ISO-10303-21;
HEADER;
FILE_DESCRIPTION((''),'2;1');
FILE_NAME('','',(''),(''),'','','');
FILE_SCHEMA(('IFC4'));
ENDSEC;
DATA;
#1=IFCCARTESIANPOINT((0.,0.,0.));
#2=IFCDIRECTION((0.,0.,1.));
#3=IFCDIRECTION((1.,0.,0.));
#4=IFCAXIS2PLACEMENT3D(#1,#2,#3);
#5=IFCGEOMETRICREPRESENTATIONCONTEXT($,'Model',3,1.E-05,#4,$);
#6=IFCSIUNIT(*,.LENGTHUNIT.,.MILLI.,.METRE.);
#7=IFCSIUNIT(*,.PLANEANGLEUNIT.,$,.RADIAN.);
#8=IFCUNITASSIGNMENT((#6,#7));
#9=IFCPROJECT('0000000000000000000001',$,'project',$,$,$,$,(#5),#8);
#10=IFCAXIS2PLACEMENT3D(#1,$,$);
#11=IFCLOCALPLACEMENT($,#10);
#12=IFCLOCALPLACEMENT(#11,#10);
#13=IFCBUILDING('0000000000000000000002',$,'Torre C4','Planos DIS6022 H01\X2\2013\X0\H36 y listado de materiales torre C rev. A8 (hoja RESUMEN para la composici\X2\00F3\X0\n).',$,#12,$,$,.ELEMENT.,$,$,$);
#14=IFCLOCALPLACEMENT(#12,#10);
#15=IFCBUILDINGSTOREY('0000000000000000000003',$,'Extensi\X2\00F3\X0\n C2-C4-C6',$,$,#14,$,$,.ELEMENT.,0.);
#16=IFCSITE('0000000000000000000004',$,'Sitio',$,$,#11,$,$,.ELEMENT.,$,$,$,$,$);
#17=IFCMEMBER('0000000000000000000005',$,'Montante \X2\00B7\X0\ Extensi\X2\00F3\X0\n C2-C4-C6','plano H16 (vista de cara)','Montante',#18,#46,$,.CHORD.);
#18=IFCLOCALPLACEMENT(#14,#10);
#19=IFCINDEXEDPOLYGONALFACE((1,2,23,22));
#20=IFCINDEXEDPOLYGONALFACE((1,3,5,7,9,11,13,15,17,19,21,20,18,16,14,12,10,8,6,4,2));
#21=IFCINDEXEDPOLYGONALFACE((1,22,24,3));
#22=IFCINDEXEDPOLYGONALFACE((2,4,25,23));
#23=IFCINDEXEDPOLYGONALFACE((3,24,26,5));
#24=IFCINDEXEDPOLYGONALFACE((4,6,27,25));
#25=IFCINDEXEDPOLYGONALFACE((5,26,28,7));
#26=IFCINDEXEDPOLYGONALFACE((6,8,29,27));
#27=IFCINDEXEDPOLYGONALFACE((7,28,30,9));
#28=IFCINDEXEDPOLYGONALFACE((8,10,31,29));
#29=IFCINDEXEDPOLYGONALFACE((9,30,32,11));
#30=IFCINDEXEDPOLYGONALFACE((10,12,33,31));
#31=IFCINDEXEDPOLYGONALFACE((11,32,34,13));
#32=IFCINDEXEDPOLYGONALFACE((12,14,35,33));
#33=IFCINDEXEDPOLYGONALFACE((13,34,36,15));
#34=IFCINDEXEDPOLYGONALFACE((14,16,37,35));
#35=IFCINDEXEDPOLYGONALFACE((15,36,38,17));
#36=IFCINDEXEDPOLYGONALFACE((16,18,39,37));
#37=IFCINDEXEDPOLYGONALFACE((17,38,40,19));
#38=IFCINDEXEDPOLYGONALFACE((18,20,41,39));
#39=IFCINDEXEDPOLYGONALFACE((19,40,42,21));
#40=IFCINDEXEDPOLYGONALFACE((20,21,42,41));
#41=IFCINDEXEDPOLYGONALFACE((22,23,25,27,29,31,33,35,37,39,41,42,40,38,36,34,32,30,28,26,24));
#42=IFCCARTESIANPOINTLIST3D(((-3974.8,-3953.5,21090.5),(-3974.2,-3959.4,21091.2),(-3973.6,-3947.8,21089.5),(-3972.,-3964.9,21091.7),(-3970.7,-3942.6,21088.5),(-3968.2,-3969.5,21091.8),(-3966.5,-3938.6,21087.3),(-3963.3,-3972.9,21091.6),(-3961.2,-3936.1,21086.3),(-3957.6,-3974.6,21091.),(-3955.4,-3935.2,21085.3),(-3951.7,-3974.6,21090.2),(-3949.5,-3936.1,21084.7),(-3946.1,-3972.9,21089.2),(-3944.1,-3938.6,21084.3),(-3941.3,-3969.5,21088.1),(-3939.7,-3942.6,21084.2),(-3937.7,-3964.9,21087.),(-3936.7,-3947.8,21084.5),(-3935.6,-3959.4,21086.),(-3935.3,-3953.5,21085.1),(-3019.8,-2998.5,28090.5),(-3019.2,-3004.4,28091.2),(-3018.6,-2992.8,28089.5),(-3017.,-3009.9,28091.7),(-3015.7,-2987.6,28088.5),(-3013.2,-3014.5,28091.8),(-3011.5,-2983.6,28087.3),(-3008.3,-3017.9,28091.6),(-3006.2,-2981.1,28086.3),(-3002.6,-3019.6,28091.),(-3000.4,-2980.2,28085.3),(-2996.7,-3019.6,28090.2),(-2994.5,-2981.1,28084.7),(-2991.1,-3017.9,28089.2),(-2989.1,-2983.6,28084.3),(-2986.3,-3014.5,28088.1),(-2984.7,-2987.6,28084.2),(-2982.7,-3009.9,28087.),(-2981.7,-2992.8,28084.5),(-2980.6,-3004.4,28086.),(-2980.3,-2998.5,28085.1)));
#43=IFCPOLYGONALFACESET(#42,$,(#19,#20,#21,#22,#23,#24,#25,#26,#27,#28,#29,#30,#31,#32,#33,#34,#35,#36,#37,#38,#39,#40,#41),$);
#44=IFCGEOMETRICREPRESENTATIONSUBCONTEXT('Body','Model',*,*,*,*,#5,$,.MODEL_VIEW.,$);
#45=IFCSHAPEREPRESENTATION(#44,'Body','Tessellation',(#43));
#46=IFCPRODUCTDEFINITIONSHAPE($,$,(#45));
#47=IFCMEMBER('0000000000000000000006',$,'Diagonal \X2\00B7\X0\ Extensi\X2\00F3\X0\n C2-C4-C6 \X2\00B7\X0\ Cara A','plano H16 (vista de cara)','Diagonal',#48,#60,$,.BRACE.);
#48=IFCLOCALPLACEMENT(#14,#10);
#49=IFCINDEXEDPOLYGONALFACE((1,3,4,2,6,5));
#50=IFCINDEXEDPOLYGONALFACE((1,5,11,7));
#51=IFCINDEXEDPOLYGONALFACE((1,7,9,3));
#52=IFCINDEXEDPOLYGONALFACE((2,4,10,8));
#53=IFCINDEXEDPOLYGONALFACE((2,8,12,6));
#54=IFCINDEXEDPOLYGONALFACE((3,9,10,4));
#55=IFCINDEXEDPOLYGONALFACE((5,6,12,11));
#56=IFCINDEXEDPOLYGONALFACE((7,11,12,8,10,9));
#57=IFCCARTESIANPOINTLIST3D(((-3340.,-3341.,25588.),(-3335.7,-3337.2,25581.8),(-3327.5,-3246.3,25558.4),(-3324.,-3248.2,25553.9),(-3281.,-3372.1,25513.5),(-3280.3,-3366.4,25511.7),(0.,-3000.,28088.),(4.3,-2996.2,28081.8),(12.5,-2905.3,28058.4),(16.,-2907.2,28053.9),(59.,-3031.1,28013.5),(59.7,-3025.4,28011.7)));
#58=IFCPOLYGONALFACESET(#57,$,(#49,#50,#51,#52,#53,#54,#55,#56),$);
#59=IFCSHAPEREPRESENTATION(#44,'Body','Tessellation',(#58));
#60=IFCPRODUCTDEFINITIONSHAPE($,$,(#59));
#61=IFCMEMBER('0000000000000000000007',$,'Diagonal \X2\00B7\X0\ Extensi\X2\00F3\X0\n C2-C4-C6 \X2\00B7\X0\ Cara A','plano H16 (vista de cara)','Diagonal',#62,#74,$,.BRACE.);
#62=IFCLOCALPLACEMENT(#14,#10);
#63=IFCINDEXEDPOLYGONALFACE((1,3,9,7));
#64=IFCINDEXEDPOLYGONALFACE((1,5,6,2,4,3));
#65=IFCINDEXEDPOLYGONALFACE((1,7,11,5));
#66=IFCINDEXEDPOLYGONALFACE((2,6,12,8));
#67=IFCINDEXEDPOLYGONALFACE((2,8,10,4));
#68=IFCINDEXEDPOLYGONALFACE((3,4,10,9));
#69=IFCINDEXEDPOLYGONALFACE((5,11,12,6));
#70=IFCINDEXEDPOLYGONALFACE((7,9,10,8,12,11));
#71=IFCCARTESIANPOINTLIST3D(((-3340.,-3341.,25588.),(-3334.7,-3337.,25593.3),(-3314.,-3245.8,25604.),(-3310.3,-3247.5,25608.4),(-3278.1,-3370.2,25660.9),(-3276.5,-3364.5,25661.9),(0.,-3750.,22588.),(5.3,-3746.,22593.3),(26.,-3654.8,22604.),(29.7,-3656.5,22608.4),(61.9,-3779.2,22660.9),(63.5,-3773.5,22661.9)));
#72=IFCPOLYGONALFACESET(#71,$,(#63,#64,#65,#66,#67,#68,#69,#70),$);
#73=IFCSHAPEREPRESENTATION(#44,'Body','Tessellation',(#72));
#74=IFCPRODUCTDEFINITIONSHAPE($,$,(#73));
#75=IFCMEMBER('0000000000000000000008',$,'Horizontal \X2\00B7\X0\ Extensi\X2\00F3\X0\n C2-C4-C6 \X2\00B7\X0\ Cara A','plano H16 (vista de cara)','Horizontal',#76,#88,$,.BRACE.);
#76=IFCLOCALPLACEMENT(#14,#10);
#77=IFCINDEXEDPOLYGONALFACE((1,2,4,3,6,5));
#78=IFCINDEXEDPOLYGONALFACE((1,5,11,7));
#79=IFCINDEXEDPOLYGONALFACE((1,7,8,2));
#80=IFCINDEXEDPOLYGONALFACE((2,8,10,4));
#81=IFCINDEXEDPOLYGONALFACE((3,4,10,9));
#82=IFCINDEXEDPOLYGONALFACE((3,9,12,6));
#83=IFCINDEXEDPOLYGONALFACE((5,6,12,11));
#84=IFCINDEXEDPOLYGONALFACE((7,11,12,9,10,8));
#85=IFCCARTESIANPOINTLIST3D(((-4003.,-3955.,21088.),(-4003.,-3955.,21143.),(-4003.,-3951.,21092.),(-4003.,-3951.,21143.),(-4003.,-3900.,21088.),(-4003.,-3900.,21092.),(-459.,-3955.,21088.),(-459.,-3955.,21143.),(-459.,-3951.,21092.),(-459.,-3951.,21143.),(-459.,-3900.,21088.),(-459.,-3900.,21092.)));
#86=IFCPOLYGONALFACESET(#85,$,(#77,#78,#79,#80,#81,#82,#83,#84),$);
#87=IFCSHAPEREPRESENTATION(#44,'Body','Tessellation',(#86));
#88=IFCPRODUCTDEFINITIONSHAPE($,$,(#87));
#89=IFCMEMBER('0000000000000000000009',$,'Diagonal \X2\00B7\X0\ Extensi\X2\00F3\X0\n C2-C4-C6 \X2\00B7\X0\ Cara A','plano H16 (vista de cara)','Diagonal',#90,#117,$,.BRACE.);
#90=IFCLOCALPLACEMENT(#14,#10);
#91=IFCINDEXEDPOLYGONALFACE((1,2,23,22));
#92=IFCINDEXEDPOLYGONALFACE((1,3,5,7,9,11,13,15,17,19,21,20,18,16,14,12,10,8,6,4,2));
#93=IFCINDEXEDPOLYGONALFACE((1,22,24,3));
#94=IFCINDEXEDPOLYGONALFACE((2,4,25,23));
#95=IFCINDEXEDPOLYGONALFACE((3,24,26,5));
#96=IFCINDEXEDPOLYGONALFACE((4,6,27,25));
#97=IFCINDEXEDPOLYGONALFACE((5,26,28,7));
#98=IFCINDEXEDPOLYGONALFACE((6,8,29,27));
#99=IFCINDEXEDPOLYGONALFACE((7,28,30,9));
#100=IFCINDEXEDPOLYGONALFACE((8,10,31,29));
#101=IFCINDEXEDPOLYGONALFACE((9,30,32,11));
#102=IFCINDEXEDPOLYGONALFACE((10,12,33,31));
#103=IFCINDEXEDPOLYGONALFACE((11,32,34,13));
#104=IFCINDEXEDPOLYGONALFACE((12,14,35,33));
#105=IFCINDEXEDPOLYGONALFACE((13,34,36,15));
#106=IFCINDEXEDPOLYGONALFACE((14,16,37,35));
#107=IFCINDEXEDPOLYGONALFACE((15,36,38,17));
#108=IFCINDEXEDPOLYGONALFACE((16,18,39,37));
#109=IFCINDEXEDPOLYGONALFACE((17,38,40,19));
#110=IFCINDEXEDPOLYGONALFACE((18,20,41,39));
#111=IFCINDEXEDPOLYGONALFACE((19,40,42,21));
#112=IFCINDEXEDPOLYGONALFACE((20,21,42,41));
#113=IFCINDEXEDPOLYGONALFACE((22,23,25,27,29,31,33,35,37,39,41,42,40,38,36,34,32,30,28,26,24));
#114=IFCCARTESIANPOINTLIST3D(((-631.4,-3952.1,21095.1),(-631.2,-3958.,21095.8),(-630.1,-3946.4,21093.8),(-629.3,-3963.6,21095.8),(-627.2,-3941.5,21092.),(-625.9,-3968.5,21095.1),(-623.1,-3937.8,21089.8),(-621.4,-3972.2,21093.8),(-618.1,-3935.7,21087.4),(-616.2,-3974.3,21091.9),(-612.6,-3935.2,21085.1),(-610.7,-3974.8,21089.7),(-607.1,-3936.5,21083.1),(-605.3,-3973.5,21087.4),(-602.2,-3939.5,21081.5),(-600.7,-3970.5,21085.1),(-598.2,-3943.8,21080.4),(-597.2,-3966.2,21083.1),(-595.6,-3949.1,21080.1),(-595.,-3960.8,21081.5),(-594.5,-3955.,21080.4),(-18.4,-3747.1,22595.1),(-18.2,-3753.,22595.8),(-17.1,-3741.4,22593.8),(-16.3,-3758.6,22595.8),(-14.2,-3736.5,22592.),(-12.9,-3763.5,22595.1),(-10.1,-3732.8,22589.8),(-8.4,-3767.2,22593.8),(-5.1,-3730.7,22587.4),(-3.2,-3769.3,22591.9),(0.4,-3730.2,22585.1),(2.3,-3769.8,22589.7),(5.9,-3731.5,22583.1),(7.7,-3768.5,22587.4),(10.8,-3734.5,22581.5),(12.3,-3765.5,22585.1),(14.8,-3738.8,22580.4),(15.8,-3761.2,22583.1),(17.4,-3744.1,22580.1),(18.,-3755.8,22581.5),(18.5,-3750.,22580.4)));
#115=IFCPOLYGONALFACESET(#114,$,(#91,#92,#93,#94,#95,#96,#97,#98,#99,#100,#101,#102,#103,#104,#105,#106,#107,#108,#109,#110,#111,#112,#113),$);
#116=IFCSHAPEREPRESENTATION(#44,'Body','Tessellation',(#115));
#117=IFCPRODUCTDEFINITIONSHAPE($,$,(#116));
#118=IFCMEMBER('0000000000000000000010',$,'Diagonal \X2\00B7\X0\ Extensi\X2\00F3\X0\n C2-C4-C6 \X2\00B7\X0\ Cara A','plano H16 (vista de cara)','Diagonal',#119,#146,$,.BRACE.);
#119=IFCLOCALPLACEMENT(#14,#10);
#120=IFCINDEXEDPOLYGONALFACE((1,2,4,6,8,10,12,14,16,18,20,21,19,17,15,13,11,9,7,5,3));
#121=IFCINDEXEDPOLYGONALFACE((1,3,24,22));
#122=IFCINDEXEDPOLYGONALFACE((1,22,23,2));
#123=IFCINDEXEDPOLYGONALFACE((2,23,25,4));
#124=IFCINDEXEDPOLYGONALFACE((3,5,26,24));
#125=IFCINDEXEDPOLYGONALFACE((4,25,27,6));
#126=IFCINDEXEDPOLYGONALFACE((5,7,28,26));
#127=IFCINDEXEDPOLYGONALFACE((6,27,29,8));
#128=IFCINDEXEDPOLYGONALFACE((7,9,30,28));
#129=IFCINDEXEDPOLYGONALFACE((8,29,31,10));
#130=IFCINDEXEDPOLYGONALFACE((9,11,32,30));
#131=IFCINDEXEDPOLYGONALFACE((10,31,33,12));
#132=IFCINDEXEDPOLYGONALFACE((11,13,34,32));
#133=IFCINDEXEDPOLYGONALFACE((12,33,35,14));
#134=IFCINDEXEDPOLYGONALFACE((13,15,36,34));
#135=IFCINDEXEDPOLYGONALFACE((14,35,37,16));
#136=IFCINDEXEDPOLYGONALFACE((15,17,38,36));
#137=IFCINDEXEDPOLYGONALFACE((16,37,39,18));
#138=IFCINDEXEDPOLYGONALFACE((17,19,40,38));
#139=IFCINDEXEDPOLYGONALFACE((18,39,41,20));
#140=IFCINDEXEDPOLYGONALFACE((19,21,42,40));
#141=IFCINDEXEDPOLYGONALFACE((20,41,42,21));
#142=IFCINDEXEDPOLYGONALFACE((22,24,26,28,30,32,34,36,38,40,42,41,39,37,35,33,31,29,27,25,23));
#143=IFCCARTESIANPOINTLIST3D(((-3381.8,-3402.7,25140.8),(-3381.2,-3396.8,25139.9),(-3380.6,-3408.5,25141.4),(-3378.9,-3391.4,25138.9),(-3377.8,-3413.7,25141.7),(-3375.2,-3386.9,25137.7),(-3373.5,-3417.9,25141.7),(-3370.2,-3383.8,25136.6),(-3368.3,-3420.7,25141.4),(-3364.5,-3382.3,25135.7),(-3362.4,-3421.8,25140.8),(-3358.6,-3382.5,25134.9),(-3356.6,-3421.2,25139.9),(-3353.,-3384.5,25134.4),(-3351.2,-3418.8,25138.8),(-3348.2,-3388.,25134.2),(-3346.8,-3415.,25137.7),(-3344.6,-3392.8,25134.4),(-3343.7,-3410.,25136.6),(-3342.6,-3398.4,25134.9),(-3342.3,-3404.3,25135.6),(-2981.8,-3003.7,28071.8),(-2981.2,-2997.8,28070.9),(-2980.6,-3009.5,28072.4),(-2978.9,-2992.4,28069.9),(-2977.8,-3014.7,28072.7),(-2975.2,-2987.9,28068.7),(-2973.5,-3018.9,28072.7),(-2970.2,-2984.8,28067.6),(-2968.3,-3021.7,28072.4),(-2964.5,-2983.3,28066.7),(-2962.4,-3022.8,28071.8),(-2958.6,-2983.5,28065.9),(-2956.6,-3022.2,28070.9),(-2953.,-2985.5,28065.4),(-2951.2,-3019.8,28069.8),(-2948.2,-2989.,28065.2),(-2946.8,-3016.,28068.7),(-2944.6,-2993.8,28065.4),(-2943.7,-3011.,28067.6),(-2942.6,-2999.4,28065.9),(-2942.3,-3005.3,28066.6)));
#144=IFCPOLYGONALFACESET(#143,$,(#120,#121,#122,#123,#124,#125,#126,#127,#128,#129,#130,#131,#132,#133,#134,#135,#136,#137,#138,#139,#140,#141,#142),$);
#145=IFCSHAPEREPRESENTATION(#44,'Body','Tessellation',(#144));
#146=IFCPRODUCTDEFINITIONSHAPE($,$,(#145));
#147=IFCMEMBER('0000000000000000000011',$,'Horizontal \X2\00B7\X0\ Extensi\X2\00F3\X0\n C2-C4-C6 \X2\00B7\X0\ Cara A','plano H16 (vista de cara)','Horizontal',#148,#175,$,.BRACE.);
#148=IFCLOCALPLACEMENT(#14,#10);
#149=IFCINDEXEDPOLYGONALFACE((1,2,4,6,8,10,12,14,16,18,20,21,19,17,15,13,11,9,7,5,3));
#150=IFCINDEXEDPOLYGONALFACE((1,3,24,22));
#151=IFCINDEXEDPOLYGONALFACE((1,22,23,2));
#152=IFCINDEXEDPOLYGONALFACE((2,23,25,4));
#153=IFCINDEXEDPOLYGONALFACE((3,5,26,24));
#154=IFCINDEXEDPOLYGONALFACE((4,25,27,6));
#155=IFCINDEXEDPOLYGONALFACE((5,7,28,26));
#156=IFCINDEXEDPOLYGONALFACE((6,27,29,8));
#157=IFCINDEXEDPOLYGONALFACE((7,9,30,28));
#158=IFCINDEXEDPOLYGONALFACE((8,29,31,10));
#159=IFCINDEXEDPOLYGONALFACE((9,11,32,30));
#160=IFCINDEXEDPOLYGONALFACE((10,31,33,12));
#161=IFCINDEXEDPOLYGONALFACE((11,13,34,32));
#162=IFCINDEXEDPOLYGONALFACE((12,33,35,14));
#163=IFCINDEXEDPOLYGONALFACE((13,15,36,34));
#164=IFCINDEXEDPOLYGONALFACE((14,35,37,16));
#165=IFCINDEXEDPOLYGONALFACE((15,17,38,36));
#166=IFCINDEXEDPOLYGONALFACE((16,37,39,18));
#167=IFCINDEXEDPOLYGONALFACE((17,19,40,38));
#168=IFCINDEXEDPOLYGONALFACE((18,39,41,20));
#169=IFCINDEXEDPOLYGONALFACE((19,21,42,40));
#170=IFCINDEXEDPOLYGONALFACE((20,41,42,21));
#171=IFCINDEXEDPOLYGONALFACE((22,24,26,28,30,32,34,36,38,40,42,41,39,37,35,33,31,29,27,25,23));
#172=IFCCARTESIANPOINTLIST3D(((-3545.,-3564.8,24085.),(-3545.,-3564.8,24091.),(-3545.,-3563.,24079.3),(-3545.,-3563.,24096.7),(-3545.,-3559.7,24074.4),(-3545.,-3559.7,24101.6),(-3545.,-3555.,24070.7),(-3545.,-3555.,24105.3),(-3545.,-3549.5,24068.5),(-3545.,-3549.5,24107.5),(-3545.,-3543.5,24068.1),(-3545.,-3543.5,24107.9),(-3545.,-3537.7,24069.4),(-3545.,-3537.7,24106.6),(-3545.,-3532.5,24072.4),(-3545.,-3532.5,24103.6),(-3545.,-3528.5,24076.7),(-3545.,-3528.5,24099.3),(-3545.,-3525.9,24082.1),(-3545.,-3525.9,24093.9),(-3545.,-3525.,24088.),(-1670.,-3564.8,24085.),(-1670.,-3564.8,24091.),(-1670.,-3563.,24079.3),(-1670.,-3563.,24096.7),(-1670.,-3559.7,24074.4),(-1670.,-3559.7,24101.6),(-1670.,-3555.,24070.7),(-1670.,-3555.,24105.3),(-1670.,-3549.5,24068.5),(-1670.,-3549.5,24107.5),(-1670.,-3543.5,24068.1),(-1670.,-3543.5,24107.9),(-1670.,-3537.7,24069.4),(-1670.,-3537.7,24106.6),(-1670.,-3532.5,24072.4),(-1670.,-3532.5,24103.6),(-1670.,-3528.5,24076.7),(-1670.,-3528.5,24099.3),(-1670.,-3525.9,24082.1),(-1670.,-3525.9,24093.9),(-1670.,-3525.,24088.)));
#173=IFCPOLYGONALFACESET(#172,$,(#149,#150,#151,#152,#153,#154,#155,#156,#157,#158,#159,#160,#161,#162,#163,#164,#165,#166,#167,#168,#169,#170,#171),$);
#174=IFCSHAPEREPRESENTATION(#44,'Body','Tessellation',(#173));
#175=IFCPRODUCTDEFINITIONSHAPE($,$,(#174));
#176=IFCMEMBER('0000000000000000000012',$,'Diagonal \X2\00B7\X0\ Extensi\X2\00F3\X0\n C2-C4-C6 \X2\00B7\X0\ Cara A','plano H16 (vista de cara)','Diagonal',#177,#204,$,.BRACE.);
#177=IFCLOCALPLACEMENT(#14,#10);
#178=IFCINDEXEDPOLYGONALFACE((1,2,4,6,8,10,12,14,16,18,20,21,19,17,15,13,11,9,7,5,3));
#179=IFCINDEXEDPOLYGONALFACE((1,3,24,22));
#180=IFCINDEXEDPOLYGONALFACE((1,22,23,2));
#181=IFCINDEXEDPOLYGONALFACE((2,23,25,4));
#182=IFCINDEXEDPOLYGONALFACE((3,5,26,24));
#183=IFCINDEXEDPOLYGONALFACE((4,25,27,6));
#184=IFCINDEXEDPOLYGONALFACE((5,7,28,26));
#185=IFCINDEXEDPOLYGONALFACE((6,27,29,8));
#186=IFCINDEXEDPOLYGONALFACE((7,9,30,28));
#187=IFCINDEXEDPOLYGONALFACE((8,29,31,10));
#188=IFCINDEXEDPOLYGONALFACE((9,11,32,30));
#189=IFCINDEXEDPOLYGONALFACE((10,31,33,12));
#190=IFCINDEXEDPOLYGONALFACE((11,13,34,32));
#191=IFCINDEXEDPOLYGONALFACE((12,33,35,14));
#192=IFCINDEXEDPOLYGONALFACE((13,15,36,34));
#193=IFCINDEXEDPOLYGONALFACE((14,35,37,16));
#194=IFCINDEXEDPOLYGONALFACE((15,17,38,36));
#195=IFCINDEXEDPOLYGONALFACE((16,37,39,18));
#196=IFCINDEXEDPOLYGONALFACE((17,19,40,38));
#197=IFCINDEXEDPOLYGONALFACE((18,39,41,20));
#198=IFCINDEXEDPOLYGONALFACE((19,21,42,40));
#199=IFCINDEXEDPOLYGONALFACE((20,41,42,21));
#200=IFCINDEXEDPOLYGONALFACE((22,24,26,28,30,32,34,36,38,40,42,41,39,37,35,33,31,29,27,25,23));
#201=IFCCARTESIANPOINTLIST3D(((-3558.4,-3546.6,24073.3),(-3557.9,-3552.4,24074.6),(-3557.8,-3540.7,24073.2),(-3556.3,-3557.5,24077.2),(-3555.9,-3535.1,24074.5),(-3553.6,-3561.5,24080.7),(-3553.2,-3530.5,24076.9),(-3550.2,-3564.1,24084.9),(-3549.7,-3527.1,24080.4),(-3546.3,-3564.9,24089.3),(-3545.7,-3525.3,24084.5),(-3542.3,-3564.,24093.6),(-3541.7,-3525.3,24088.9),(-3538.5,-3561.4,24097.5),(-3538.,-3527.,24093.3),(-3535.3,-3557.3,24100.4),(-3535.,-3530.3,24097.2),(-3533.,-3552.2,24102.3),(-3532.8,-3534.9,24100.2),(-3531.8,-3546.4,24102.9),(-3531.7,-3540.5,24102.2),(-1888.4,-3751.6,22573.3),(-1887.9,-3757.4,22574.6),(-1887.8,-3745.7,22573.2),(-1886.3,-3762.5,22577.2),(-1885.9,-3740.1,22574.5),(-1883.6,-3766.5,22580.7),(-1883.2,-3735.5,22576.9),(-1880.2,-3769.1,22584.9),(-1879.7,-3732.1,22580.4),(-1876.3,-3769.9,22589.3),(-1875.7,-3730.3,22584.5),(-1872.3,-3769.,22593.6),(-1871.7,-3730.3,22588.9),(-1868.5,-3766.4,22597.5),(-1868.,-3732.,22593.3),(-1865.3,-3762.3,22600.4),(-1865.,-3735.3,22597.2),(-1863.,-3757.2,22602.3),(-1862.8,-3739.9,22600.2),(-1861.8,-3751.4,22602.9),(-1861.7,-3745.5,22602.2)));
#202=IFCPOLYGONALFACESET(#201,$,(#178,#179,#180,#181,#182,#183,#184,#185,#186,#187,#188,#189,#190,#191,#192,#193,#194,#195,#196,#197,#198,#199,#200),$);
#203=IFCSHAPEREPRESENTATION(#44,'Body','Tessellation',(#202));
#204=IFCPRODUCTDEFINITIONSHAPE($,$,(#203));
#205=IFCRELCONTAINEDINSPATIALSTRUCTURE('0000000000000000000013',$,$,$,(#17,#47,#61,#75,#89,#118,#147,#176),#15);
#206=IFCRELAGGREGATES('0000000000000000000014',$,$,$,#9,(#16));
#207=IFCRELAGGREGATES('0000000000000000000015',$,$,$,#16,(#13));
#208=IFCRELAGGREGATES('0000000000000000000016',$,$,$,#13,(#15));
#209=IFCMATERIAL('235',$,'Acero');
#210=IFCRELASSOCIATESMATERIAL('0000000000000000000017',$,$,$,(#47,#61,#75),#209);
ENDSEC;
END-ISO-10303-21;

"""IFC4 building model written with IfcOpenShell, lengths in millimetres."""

from ifc_helpers import new_model, si_unit, frame, frame_2d, origin, origin_with_axes, place, context, subcontext, project, spatial, circle, l_section, extrude, material, element, save


model = new_model("IFC4")

# Units and contexts
model_context = context("Model", 3, precision=1e-05, world=origin_with_axes())
body_context = subcontext(model_context, "Body", "Model", "MODEL_VIEW")
ifc_project = project(units=[si_unit("LENGTHUNIT", "METRE", prefix="MILLI"), si_unit("PLANEANGLEUNIT", "RADIAN")], contexts=[model_context])

# Site, building, storey
site_placement = place(None, origin())
site = spatial("IfcSite", under=ifc_project, at=site_placement, Name="Sitio", CompositionType="ELEMENT")
building_placement = place(site_placement, origin())
building = spatial("IfcBuilding", under=site, at=building_placement, Name="Torre C4", Description="Planos DIS6022 H01–H36 y listado de materiales torre C rev. A8 (hoja RESUMEN para la composición).", CompositionType="ELEMENT")
storey_placement = place(building_placement, origin())
storey = spatial("IfcBuildingStorey", under=building, at=storey_placement, Name="Extensión C2-C4-C6", CompositionType="ELEMENT", Elevation=0.0)

# Members
member_1_placement = place(storey_placement, frame((-3000.0, -3000.0, 28088.0), z_axis=(-0.133958, -0.133958, -0.981891), x_axis=(-0.018108, 0.990987, -0.132728)))
element("IfcMember", 1, at=member_1_placement, inside=storey, Name="Montante · Extensión C2-C4-C6", Description="plano H16 (vista de cara)", ObjectType="Montante", PredefinedType="CHORD", context=body_context, shape_type="SweptSolid", body=[
    extrude(circle(Radius=20.0), None, (0.0, 0.0, 1.0), 7129.1),
])
ifc_material_1 = material(Name="235", Category="Acero")
member_2_placement = place(storey_placement, frame((0.0, -3000.0, 28088.0), z_axis=(-0.797914, -0.081464, -0.597241), x_axis=(0.124785, 0.947037, -0.295888)))
element("IfcMember", 2, at=member_2_placement, inside=storey, material=ifc_material_1, Name="Diagonal · Extensión C2-C4-C6 · Cara A", Description="plano H16 (vista de cara)", ObjectType="Diagonal", PredefinedType="BRACE", context=body_context, shape_type="SweptSolid", body=[
    extrude(l_section(Depth=100.0, Width=100.0, Thickness=6.0, at=frame_2d((50.0, 50.0))), None, (0.0, 0.0, 1.0), 4185.9),
])
member_3_placement = place(storey_placement, frame((-3340.0, -3341.0, 25588.0), z_axis=(0.74089, -0.090726, -0.66547), x_axis=(0.260225, 0.952216, 0.159898)))
element("IfcMember", 3, at=member_3_placement, inside=storey, material=ifc_material_1, Name="Diagonal · Extensión C2-C4-C6 · Cara A", Description="plano H16 (vista de cara)", ObjectType="Diagonal", PredefinedType="BRACE", context=body_context, shape_type="SweptSolid", body=[
    extrude(l_section(Depth=100.0, Width=100.0, Thickness=6.0, at=frame_2d((50.0, 50.0))), None, (0.0, 0.0, 1.0), 4508.1),
])
member_4_placement = place(storey_placement, frame((-4003.0, -3955.0, 21088.0), z_axis=(1.0, 0.0, 0.0), x_axis=(0.0, 1.0, 0.0)))
element("IfcMember", 4, at=member_4_placement, inside=storey, material=ifc_material_1, Name="Horizontal · Extensión C2-C4-C6 · Cara A", Description="plano H16 (vista de cara)", ObjectType="Horizontal", PredefinedType="BRACE", context=body_context, shape_type="SweptSolid", body=[
    extrude(l_section(Depth=55.0, Width=55.0, Thickness=4.0, at=frame_2d((27.5, 27.5))), None, (0.0, 0.0, 1.0), 3544.0),
])
member_5_placement = place(storey_placement, frame((0.0, -3750.0, 22588.0), z_axis=(-0.375305, -0.12551, -0.918365), x_axis=(0.02144, 0.989349, -0.143973)))
element("IfcMember", 5, at=member_5_placement, inside=storey, Name="Diagonal · Extensión C2-C4-C6 · Cara A", Description="plano H16 (vista de cara)", ObjectType="Diagonal", PredefinedType="BRACE", context=body_context, shape_type="SweptSolid", body=[
    extrude(circle(Radius=20.0), None, (0.0, 0.0, 1.0), 1633.3),
])
member_6_placement = place(storey_placement, frame((-2962.0, -3003.0, 28069.0), z_axis=(-0.134005, -0.13367, -0.981924), x_axis=(0.689696, 0.698925, -0.18927)))
element("IfcMember", 6, at=member_6_placement, inside=storey, Name="Diagonal · Extensión C2-C4-C6 · Cara A", Description="plano H16 (vista de cara)", ObjectType="Diagonal", PredefinedType="BRACE", context=body_context, shape_type="SweptSolid", body=[
    extrude(circle(Radius=20.0), None, (0.0, 0.0, 1.0), 2985.0),
])
member_7_placement = place(storey_placement, frame((-1670.0, -3545.0, 24088.0), z_axis=(-1.0, 0.0, 0.0), x_axis=(0.0, 1.0, 0.0)))
element("IfcMember", 7, at=member_7_placement, inside=storey, Name="Horizontal · Extensión C2-C4-C6 · Cara A", Description="plano H16 (vista de cara)", ObjectType="Horizontal", PredefinedType="BRACE", context=body_context, shape_type="SweptSolid", body=[
    extrude(circle(Radius=20.0), None, (0.0, 0.0, 1.0), 1875.0),
])
member_8_placement = place(storey_placement, frame((-3545.0, -3545.0, 24088.0), z_axis=(0.740875, -0.090946, -0.665457), x_axis=(0.347628, 0.899679, 0.264069)))
element("IfcMember", 8, at=member_8_placement, inside=storey, Name="Diagonal · Extensión C2-C4-C6 · Cara A", Description="plano H16 (vista de cara)", ObjectType="Diagonal", PredefinedType="BRACE", context=body_context, shape_type="SweptSolid", body=[
    extrude(circle(Radius=20.0), None, (0.0, 0.0, 1.0), 2254.1),
])

save(model, "model.ifc")
